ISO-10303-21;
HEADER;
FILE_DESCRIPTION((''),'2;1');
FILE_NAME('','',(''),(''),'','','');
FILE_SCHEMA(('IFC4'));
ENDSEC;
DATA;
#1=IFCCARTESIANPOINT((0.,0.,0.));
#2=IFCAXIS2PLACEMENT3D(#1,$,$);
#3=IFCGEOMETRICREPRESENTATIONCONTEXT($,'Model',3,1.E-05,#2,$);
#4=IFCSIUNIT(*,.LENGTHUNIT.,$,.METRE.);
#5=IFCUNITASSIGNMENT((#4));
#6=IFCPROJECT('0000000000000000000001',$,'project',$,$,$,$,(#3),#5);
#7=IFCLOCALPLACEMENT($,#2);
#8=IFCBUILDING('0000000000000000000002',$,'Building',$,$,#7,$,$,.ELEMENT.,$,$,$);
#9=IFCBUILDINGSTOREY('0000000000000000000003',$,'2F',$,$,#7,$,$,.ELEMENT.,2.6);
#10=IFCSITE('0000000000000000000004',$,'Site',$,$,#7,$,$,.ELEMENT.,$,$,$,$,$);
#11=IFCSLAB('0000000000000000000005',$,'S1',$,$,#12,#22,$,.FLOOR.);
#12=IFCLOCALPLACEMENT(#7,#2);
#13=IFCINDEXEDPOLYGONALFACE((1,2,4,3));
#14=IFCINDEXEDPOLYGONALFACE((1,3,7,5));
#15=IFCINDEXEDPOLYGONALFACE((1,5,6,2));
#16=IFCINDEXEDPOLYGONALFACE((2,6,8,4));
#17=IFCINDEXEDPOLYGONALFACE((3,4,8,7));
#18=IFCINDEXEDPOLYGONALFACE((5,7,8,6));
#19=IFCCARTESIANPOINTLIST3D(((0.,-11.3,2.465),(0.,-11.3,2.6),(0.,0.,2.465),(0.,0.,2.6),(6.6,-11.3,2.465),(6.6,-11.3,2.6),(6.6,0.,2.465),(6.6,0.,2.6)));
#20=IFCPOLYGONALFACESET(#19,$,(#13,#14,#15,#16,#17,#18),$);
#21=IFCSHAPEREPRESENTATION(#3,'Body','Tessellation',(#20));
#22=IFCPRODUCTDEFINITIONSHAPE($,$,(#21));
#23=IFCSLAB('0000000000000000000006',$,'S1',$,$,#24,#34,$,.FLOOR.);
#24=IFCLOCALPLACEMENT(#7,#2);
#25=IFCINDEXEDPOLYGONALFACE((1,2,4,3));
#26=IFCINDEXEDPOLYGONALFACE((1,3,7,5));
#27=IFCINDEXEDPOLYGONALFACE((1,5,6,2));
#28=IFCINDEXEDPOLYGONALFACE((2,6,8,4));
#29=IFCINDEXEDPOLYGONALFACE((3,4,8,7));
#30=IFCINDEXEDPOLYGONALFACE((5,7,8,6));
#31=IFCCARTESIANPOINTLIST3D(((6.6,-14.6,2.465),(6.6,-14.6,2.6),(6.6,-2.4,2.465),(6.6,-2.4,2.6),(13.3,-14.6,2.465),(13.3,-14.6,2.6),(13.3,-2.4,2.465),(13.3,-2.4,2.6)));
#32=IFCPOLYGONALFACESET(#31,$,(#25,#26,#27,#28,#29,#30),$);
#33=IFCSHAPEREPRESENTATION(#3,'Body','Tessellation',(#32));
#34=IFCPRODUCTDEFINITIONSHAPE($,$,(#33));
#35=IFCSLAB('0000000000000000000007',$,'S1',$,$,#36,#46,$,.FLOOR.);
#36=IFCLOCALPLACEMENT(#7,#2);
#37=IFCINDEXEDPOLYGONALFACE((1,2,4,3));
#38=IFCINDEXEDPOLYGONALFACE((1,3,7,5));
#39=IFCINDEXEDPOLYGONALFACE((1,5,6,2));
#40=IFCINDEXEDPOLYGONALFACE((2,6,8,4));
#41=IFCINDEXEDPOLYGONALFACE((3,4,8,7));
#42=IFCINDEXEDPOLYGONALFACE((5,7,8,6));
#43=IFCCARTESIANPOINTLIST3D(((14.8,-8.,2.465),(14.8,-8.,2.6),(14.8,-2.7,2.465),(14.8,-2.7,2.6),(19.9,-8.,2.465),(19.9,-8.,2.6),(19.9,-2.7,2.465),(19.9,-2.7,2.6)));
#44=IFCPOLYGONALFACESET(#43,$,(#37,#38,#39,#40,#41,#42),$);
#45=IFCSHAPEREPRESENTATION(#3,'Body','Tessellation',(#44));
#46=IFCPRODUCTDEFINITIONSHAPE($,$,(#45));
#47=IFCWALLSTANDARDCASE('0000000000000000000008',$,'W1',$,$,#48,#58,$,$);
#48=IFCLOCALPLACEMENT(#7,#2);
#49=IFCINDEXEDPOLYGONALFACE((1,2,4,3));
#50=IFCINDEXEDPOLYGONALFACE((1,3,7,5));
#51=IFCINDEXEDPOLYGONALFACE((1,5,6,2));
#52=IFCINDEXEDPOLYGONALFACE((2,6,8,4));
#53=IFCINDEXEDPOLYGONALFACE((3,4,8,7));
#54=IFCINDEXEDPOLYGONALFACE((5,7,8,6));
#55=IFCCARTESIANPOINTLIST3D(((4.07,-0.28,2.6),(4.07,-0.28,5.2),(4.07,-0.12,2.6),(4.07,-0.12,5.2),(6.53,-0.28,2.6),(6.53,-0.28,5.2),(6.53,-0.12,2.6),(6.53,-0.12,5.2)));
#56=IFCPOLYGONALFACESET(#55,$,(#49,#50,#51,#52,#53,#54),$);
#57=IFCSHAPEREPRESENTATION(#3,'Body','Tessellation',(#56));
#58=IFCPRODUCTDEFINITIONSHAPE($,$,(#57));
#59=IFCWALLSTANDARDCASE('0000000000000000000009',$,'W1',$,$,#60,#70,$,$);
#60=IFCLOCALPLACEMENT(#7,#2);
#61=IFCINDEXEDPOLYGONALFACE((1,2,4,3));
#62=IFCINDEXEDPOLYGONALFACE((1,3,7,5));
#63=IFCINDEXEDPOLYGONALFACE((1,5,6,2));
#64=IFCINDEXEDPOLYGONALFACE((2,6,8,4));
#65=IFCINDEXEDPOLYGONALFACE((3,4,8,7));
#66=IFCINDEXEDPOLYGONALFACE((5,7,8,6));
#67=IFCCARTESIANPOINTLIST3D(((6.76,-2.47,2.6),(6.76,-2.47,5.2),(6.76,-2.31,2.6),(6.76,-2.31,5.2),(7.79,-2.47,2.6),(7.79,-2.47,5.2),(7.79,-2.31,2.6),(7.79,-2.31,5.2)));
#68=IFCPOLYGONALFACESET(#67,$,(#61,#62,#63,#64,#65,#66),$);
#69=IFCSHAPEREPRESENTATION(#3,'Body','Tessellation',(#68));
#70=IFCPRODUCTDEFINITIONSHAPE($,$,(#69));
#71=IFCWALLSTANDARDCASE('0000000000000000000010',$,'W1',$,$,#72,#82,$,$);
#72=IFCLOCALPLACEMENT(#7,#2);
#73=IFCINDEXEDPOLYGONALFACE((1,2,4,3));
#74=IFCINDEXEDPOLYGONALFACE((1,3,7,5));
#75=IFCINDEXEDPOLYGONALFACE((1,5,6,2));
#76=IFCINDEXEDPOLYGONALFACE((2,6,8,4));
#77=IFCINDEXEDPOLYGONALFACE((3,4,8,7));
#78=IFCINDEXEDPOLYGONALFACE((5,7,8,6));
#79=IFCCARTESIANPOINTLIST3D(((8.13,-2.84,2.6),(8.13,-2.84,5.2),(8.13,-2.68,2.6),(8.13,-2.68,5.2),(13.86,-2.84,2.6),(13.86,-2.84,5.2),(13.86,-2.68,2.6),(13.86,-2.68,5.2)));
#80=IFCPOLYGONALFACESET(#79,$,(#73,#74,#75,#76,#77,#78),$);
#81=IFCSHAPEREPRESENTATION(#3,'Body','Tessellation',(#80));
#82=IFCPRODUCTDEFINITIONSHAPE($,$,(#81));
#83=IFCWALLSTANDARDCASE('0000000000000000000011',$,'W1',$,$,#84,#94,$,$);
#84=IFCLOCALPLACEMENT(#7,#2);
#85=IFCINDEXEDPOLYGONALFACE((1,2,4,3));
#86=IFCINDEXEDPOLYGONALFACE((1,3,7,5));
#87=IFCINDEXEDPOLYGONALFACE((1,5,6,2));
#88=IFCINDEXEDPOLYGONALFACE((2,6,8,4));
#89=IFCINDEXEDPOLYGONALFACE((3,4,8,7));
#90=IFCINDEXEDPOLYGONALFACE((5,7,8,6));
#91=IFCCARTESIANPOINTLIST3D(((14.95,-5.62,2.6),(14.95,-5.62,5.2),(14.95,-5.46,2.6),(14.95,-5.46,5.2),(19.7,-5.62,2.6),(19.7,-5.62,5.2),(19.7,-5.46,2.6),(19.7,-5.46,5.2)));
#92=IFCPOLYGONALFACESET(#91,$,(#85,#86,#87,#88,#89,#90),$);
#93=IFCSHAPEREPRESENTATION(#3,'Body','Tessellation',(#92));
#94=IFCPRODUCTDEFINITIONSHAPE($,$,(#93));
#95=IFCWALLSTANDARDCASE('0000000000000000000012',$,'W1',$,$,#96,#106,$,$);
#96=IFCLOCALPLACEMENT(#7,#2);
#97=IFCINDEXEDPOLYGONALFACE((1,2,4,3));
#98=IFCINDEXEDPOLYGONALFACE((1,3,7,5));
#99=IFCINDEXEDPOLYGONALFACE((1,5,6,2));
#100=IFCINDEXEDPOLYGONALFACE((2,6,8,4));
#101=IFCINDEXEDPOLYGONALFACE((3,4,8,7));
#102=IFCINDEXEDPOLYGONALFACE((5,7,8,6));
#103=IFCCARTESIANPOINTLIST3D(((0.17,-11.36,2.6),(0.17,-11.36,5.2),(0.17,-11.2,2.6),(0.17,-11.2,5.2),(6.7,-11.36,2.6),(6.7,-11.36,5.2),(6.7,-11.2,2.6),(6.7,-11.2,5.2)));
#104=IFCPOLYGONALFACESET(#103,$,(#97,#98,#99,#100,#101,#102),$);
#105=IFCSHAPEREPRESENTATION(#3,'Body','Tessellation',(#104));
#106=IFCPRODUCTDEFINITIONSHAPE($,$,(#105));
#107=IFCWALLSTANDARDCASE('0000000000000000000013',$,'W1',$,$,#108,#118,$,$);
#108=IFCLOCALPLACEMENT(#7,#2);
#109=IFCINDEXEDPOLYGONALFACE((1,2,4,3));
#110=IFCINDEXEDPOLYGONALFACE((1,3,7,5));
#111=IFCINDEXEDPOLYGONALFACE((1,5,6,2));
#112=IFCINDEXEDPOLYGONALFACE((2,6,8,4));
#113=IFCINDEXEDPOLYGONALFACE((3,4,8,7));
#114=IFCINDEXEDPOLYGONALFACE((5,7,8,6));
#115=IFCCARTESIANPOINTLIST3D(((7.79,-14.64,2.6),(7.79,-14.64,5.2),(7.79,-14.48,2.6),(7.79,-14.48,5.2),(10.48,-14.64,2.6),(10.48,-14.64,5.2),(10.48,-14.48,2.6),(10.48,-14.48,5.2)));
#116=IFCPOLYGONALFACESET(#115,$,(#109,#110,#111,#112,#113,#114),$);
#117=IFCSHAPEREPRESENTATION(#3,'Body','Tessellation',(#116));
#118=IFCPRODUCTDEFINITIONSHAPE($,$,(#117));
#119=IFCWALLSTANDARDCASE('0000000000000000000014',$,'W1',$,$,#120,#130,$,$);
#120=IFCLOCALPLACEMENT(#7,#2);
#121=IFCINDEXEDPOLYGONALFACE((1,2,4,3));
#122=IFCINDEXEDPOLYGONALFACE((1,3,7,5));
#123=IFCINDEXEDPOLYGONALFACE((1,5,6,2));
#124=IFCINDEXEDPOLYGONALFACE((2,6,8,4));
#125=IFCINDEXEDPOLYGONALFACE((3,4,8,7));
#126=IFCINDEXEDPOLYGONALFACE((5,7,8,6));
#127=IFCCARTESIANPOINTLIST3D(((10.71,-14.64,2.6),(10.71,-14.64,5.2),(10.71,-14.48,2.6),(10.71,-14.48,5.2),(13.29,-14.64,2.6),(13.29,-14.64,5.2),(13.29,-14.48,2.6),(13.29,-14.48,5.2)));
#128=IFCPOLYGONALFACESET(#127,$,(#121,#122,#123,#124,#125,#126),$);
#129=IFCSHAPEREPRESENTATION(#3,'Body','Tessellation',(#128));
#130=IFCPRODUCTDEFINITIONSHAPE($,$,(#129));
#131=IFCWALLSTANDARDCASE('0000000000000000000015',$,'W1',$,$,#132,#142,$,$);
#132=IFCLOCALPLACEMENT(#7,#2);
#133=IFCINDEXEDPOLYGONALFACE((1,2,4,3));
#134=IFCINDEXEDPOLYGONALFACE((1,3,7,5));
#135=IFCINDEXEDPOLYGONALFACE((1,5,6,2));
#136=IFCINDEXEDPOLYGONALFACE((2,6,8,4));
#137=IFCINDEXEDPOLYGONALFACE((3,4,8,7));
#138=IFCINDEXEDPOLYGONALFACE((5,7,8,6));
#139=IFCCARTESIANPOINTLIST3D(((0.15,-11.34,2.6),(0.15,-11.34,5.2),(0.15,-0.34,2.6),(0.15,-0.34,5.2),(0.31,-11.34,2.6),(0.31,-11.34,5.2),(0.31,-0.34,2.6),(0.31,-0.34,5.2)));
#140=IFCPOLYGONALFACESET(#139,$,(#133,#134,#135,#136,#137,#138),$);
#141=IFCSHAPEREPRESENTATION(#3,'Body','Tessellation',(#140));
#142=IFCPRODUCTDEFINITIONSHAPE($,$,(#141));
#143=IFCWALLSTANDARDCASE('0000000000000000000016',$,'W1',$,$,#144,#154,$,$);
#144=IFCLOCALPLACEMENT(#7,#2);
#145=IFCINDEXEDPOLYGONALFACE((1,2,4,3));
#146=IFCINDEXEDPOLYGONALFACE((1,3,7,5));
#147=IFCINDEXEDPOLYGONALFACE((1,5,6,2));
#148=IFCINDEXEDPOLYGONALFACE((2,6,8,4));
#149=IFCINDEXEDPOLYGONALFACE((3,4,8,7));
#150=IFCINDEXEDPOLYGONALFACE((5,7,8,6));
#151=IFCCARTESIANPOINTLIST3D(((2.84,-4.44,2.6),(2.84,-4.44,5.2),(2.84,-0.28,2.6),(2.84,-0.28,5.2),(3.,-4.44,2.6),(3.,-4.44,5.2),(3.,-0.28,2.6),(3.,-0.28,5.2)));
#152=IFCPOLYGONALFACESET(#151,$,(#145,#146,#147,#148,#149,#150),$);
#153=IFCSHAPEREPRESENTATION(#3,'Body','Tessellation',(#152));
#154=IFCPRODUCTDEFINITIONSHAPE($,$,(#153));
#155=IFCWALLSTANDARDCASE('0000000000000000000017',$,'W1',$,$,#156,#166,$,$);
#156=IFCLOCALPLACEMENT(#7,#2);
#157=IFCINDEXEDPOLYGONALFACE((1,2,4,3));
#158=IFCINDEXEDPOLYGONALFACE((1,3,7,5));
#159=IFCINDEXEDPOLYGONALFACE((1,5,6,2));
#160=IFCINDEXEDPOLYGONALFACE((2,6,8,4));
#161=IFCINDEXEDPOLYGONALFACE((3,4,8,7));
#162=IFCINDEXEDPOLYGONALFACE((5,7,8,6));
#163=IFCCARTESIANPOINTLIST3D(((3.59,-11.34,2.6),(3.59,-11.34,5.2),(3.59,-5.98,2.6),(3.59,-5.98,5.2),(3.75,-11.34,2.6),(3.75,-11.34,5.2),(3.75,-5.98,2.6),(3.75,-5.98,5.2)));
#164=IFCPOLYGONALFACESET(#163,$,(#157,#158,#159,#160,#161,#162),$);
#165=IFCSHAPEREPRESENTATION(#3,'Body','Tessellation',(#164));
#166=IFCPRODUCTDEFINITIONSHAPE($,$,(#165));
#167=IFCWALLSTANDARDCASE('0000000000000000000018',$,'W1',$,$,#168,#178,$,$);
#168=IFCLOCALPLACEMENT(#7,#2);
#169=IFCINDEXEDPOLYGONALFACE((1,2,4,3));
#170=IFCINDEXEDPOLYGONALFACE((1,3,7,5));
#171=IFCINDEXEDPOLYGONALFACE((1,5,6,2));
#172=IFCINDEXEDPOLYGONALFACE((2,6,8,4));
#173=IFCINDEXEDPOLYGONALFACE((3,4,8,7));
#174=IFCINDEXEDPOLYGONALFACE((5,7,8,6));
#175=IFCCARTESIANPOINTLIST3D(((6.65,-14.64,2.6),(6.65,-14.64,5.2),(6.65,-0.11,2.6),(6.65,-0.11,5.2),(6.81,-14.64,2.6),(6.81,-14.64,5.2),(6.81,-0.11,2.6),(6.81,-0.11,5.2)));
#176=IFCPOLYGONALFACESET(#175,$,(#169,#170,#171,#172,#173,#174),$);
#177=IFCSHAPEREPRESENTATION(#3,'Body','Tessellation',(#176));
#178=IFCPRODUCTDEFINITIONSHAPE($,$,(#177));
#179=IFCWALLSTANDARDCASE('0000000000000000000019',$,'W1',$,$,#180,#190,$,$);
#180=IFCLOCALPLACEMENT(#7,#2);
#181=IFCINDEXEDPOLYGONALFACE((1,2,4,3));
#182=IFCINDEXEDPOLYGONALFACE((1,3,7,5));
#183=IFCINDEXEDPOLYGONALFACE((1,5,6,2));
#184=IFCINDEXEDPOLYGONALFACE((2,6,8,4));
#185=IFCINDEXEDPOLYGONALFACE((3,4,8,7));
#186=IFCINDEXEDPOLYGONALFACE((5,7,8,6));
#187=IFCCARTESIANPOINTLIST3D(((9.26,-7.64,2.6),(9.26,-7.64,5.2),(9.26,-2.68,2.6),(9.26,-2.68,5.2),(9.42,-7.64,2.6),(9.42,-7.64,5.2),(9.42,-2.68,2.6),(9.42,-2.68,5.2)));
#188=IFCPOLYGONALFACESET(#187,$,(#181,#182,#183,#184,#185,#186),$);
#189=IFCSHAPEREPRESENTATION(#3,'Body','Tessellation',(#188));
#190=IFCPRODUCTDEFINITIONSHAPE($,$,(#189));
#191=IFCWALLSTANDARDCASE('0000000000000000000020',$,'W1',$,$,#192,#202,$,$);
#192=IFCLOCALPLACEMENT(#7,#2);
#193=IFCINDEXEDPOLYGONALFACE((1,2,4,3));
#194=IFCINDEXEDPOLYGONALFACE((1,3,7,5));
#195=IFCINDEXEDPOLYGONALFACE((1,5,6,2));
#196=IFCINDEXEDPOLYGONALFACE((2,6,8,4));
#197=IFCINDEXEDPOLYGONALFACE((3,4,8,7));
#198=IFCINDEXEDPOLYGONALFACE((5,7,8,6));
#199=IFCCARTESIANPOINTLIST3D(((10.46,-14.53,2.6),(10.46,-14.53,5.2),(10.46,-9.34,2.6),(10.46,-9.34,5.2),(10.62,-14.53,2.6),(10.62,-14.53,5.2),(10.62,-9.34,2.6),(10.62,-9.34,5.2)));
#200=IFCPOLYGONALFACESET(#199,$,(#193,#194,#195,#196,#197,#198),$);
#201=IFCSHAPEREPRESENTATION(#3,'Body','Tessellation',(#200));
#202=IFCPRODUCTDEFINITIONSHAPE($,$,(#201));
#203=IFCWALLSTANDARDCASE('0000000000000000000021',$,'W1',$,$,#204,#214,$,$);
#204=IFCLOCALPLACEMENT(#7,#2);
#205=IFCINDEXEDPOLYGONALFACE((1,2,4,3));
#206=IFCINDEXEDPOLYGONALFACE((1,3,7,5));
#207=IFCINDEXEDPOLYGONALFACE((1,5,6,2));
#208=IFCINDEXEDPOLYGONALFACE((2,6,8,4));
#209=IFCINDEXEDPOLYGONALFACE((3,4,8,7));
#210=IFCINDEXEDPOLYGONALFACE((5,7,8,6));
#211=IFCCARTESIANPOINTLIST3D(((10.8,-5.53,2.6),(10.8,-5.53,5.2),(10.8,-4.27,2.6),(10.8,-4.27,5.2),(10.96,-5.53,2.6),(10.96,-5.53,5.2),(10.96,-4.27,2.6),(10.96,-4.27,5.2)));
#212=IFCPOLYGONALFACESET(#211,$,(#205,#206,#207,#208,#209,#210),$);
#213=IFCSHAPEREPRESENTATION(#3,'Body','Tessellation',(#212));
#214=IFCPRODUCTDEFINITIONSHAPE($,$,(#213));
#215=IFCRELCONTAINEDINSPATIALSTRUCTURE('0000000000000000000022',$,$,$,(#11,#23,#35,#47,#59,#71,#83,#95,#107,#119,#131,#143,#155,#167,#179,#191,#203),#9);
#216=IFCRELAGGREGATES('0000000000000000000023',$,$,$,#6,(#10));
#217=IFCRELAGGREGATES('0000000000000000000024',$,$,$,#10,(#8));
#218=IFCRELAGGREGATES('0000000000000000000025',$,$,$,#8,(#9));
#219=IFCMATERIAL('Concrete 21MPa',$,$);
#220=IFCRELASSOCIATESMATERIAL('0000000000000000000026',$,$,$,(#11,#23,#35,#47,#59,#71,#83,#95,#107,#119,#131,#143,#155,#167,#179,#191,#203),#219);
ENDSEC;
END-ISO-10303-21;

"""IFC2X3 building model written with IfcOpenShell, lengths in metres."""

from ifc_helpers import new_model, si_unit, frame, origin, origin_2d, place, context, project, spatial, rectangle, extrude, material, element, save


model = new_model("IFC2X3")

# Units and contexts
model_context = context("Model", 3, precision=1e-05, world=origin())
ifc_project = project(units=[si_unit("LENGTHUNIT", "METRE")], contexts=[model_context])

# Site, building, storey
placement = place(None, origin())
site = spatial("IfcSite", under=ifc_project, at=placement, Name="Site", CompositionType="ELEMENT")
building = spatial("IfcBuilding", under=site, at=placement, Name="Building", CompositionType="ELEMENT")
storey = spatial("IfcBuildingStorey", under=building, at=placement, Name="2F", CompositionType="ELEMENT", Elevation=2.6)

# Slabs
ifc_material_1 = material(Name="Concrete 21MPa")
slab_1_placement = place(None, frame((3.3, -5.65, 2.465)))
element("IfcSlab", 1, at=slab_1_placement, inside=storey, material=ifc_material_1, Name="S1", PredefinedType="FLOOR", context=model_context, shape_type="SweptSolid", body=[
    extrude(rectangle(XDim=6.6, YDim=11.3, at=origin_2d()), origin(), (0.0, 0.0, 1.0), 0.135),
])
slab_2_placement = place(None, frame((9.95, -8.5, 2.465)))
element("IfcSlab", 2, at=slab_2_placement, inside=storey, material=ifc_material_1, Name="S1", PredefinedType="FLOOR", context=model_context, shape_type="SweptSolid", body=[
    extrude(rectangle(XDim=6.7, YDim=12.2, at=origin_2d()), origin(), (0.0, 0.0, 1.0), 0.135),
])
slab_3_placement = place(None, frame((17.35, -5.35, 2.465)))
element("IfcSlab", 3, at=slab_3_placement, inside=storey, material=ifc_material_1, Name="S1", PredefinedType="FLOOR", context=model_context, shape_type="SweptSolid", body=[
    extrude(rectangle(XDim=5.1, YDim=5.3, at=origin_2d()), origin(), (0.0, 0.0, 1.0), 0.135),
])

# Walls
wall_1_placement = place(None, frame((5.3, -0.2, 2.6)))
element("IfcWallStandardCase", 4, at=wall_1_placement, inside=storey, material=ifc_material_1, Name="W1", context=model_context, shape_type="SweptSolid", body=[
    extrude(rectangle(XDim=2.46, YDim=0.16, at=origin_2d()), origin(), (0.0, 0.0, 1.0), 2.6),
])
wall_2_placement = place(None, frame((7.275, -2.39, 2.6)))
element("IfcWallStandardCase", 5, at=wall_2_placement, inside=storey, material=ifc_material_1, Name="W1", context=model_context, shape_type="SweptSolid", body=[
    extrude(rectangle(XDim=1.03, YDim=0.16, at=origin_2d()), origin(), (0.0, 0.0, 1.0), 2.6),
])
wall_3_placement = place(None, frame((10.995, -2.76, 2.6)))
element("IfcWallStandardCase", 6, at=wall_3_placement, inside=storey, material=ifc_material_1, Name="W1", context=model_context, shape_type="SweptSolid", body=[
    extrude(rectangle(XDim=5.73, YDim=0.16, at=origin_2d()), origin(), (0.0, 0.0, 1.0), 2.6),
])
wall_4_placement = place(None, frame((17.325, -5.54, 2.6)))
element("IfcWallStandardCase", 7, at=wall_4_placement, inside=storey, material=ifc_material_1, Name="W1", context=model_context, shape_type="SweptSolid", body=[
    extrude(rectangle(XDim=4.75, YDim=0.16, at=origin_2d()), origin(), (0.0, 0.0, 1.0), 2.6),
])
wall_5_placement = place(None, frame((3.435, -11.28, 2.6)))
element("IfcWallStandardCase", 8, at=wall_5_placement, inside=storey, material=ifc_material_1, Name="W1", context=model_context, shape_type="SweptSolid", body=[
    extrude(rectangle(XDim=6.53, YDim=0.16, at=origin_2d()), origin(), (0.0, 0.0, 1.0), 2.6),
])
wall_6_placement = place(None, frame((9.135, -14.56, 2.6)))
element("IfcWallStandardCase", 9, at=wall_6_placement, inside=storey, material=ifc_material_1, Name="W1", context=model_context, shape_type="SweptSolid", body=[
    extrude(rectangle(XDim=2.69, YDim=0.16, at=origin_2d()), origin(), (0.0, 0.0, 1.0), 2.6),
])
wall_7_placement = place(None, frame((12.0, -14.56, 2.6)))
element("IfcWallStandardCase", 10, at=wall_7_placement, inside=storey, material=ifc_material_1, Name="W1", context=model_context, shape_type="SweptSolid", body=[
    extrude(rectangle(XDim=2.58, YDim=0.16, at=origin_2d()), origin(), (0.0, 0.0, 1.0), 2.6),
])
wall_8_placement = place(None, frame((0.23, -5.84, 2.6)))
element("IfcWallStandardCase", 11, at=wall_8_placement, inside=storey, material=ifc_material_1, Name="W1", context=model_context, shape_type="SweptSolid", body=[
    extrude(rectangle(XDim=0.16, YDim=11.0, at=origin_2d()), origin(), (0.0, 0.0, 1.0), 2.6),
])
wall_9_placement = place(None, frame((2.92, -2.36, 2.6)))
element("IfcWallStandardCase", 12, at=wall_9_placement, inside=storey, material=ifc_material_1, Name="W1", context=model_context, shape_type="SweptSolid", body=[
    extrude(rectangle(XDim=0.16, YDim=4.16, at=origin_2d()), origin(), (0.0, 0.0, 1.0), 2.6),
])
wall_10_placement = place(None, frame((3.67, -8.66, 2.6)))
element("IfcWallStandardCase", 13, at=wall_10_placement, inside=storey, material=ifc_material_1, Name="W1", context=model_context, shape_type="SweptSolid", body=[
    extrude(rectangle(XDim=0.16, YDim=5.36, at=origin_2d()), origin(), (0.0, 0.0, 1.0), 2.6),
])
wall_11_placement = place(None, frame((6.73, -7.375, 2.6)))
element("IfcWallStandardCase", 14, at=wall_11_placement, inside=storey, material=ifc_material_1, Name="W1", context=model_context, shape_type="SweptSolid", body=[
    extrude(rectangle(XDim=0.16, YDim=14.53, at=origin_2d()), origin(), (0.0, 0.0, 1.0), 2.6),
])
wall_12_placement = place(None, frame((9.34, -5.16, 2.6)))
element("IfcWallStandardCase", 15, at=wall_12_placement, inside=storey, material=ifc_material_1, Name="W1", context=model_context, shape_type="SweptSolid", body=[
    extrude(rectangle(XDim=0.16, YDim=4.96, at=origin_2d()), origin(), (0.0, 0.0, 1.0), 2.6),
])
wall_13_placement = place(None, frame((10.54, -11.935, 2.6)))
element("IfcWallStandardCase", 16, at=wall_13_placement, inside=storey, material=ifc_material_1, Name="W1", context=model_context, shape_type="SweptSolid", body=[
    extrude(rectangle(XDim=0.16, YDim=5.19, at=origin_2d()), origin(), (0.0, 0.0, 1.0), 2.6),
])
wall_14_placement = place(None, frame((10.88, -4.9, 2.6)))
element("IfcWallStandardCase", 17, at=wall_14_placement, inside=storey, material=ifc_material_1, Name="W1", context=model_context, shape_type="SweptSolid", body=[
    extrude(rectangle(XDim=0.16, YDim=1.26, at=origin_2d()), origin(), (0.0, 0.0, 1.0), 2.6),
])

save(model, "model.ifc")
